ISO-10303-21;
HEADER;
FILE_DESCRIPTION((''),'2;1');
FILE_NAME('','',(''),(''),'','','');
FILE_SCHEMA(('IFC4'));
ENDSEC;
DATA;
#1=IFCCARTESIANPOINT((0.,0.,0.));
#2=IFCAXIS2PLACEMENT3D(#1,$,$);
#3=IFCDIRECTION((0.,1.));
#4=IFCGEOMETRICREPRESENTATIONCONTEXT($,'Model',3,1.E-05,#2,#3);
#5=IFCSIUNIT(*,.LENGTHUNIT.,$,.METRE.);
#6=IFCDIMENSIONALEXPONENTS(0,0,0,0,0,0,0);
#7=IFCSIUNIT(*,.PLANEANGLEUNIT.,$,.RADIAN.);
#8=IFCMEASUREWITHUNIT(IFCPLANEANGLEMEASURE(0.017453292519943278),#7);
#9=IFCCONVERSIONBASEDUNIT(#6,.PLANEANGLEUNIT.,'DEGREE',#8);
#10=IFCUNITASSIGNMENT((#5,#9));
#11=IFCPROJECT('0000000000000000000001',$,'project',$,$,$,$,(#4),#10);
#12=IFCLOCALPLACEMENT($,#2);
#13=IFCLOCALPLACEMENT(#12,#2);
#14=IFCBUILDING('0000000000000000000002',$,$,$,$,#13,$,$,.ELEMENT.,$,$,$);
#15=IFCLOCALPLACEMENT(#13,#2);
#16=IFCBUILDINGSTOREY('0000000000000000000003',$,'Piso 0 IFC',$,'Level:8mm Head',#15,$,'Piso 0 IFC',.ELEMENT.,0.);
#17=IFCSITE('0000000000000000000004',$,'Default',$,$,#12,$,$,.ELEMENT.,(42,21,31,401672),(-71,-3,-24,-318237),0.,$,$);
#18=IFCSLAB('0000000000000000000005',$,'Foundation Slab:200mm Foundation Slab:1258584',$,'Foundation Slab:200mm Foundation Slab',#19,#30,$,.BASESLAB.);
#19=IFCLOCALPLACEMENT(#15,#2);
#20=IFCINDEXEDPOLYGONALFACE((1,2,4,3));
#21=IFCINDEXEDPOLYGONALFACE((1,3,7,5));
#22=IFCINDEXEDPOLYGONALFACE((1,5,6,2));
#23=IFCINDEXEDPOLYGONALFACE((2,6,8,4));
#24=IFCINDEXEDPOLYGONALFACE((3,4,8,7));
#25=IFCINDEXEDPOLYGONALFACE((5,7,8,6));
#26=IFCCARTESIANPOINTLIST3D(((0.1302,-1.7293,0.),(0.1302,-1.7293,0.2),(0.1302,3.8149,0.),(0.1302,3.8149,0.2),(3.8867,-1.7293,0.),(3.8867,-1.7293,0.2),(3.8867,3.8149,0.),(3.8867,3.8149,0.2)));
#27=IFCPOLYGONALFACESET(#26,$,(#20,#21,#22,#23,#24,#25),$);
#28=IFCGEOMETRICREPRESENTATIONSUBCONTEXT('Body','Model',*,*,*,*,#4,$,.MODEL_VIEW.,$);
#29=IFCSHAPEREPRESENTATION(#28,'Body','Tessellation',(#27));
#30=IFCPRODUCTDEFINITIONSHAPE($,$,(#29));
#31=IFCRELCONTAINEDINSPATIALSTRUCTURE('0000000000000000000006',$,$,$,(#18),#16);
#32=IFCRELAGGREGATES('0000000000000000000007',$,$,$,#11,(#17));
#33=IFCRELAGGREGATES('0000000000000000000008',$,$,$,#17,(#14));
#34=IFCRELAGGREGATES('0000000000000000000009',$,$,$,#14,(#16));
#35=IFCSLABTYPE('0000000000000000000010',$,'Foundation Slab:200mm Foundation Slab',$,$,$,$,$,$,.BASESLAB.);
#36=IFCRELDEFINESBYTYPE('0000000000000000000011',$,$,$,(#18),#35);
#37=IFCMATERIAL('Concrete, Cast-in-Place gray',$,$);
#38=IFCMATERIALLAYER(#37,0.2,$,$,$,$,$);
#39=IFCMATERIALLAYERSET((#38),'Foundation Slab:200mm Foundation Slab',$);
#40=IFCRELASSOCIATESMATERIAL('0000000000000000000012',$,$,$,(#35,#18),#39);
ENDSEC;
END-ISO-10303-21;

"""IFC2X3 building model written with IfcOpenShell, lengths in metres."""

from ifc_helpers import new_model, entity, si_unit, converted_unit, direction, frame, origin, origin_2d_with_axis, place, context, subcontext, project, spatial, rectangle, extrude, material, layer, layer_set, layer_usage, type_object, element, save


model = new_model("IFC2X3")

# Units and contexts
model_context = context("Model", 3, precision=1e-05, world=origin(), true_north=direction((0.0, 1.0)))
body_context = subcontext(model_context, "Body", "Model", "MODEL_VIEW")
ifc_project = project(units=[si_unit("LENGTHUNIT", "METRE"), converted_unit("PLANEANGLEUNIT", "DEGREE", entity("IfcPlaneAngleMeasure", 0.017453292519943278), si_unit("PLANEANGLEUNIT", "RADIAN"), dimensions=[0, 0, 0, 0, 0, 0, 0])], contexts=[model_context])

# Site, building, storey
site_placement = place(None, origin())
site = spatial("IfcSite", under=ifc_project, at=site_placement, Name="Default", CompositionType="ELEMENT", RefLatitude=(42, 21, 31, 401672), RefLongitude=(-71, -3, -24, -318237), RefElevation=0.0)
building_placement = place(site_placement, origin())
building = spatial("IfcBuilding", under=site, at=building_placement, CompositionType="ELEMENT")
storey_placement = place(building_placement, origin())
storey = spatial("IfcBuildingStorey", under=building, at=storey_placement, Name="Piso 0 IFC", ObjectType="Level:8mm Head", LongName="Piso 0 IFC", CompositionType="ELEMENT", Elevation=0.0)

# Shared definitions
ifc_material_1 = material(Name="Concrete, Cast-in-Place gray")

# Slab
ifc_layer_1 = layer(ifc_material_1, 0.2)
ifc_layer_set_1 = layer_set([ifc_layer_1], Name="Foundation Slab:200mm Foundation Slab")
ifc_layer_usage_1 = layer_usage(ifc_layer_set_1, "AXIS3", "POSITIVE", 0.0)
slab_type_1 = type_object("IfcSlabType", Name="Foundation Slab:200mm Foundation Slab", PredefinedType="BASESLAB", material=ifc_layer_set_1)
slab_1_placement = place(storey_placement, origin())
element("IfcSlab", 1, at=slab_1_placement, inside=storey, type_object=slab_type_1, material=ifc_layer_usage_1, Name="Foundation Slab:200mm Foundation Slab:1258584", ObjectType="Foundation Slab:200mm Foundation Slab", PredefinedType="BASESLAB", context=body_context, shape_type="SweptSolid", body=[
    extrude(rectangle(XDim=5.5441, YDim=3.7565, at=origin_2d_with_axis()), frame((2.0084, 1.0428, 0.2), z_axis=(0.0, 0.0, -1.0), x_axis=(0.0, 1.0, 0.0)), (0.0, 0.0, 1.0), 0.2),
])

save(model, "model.ifc")
